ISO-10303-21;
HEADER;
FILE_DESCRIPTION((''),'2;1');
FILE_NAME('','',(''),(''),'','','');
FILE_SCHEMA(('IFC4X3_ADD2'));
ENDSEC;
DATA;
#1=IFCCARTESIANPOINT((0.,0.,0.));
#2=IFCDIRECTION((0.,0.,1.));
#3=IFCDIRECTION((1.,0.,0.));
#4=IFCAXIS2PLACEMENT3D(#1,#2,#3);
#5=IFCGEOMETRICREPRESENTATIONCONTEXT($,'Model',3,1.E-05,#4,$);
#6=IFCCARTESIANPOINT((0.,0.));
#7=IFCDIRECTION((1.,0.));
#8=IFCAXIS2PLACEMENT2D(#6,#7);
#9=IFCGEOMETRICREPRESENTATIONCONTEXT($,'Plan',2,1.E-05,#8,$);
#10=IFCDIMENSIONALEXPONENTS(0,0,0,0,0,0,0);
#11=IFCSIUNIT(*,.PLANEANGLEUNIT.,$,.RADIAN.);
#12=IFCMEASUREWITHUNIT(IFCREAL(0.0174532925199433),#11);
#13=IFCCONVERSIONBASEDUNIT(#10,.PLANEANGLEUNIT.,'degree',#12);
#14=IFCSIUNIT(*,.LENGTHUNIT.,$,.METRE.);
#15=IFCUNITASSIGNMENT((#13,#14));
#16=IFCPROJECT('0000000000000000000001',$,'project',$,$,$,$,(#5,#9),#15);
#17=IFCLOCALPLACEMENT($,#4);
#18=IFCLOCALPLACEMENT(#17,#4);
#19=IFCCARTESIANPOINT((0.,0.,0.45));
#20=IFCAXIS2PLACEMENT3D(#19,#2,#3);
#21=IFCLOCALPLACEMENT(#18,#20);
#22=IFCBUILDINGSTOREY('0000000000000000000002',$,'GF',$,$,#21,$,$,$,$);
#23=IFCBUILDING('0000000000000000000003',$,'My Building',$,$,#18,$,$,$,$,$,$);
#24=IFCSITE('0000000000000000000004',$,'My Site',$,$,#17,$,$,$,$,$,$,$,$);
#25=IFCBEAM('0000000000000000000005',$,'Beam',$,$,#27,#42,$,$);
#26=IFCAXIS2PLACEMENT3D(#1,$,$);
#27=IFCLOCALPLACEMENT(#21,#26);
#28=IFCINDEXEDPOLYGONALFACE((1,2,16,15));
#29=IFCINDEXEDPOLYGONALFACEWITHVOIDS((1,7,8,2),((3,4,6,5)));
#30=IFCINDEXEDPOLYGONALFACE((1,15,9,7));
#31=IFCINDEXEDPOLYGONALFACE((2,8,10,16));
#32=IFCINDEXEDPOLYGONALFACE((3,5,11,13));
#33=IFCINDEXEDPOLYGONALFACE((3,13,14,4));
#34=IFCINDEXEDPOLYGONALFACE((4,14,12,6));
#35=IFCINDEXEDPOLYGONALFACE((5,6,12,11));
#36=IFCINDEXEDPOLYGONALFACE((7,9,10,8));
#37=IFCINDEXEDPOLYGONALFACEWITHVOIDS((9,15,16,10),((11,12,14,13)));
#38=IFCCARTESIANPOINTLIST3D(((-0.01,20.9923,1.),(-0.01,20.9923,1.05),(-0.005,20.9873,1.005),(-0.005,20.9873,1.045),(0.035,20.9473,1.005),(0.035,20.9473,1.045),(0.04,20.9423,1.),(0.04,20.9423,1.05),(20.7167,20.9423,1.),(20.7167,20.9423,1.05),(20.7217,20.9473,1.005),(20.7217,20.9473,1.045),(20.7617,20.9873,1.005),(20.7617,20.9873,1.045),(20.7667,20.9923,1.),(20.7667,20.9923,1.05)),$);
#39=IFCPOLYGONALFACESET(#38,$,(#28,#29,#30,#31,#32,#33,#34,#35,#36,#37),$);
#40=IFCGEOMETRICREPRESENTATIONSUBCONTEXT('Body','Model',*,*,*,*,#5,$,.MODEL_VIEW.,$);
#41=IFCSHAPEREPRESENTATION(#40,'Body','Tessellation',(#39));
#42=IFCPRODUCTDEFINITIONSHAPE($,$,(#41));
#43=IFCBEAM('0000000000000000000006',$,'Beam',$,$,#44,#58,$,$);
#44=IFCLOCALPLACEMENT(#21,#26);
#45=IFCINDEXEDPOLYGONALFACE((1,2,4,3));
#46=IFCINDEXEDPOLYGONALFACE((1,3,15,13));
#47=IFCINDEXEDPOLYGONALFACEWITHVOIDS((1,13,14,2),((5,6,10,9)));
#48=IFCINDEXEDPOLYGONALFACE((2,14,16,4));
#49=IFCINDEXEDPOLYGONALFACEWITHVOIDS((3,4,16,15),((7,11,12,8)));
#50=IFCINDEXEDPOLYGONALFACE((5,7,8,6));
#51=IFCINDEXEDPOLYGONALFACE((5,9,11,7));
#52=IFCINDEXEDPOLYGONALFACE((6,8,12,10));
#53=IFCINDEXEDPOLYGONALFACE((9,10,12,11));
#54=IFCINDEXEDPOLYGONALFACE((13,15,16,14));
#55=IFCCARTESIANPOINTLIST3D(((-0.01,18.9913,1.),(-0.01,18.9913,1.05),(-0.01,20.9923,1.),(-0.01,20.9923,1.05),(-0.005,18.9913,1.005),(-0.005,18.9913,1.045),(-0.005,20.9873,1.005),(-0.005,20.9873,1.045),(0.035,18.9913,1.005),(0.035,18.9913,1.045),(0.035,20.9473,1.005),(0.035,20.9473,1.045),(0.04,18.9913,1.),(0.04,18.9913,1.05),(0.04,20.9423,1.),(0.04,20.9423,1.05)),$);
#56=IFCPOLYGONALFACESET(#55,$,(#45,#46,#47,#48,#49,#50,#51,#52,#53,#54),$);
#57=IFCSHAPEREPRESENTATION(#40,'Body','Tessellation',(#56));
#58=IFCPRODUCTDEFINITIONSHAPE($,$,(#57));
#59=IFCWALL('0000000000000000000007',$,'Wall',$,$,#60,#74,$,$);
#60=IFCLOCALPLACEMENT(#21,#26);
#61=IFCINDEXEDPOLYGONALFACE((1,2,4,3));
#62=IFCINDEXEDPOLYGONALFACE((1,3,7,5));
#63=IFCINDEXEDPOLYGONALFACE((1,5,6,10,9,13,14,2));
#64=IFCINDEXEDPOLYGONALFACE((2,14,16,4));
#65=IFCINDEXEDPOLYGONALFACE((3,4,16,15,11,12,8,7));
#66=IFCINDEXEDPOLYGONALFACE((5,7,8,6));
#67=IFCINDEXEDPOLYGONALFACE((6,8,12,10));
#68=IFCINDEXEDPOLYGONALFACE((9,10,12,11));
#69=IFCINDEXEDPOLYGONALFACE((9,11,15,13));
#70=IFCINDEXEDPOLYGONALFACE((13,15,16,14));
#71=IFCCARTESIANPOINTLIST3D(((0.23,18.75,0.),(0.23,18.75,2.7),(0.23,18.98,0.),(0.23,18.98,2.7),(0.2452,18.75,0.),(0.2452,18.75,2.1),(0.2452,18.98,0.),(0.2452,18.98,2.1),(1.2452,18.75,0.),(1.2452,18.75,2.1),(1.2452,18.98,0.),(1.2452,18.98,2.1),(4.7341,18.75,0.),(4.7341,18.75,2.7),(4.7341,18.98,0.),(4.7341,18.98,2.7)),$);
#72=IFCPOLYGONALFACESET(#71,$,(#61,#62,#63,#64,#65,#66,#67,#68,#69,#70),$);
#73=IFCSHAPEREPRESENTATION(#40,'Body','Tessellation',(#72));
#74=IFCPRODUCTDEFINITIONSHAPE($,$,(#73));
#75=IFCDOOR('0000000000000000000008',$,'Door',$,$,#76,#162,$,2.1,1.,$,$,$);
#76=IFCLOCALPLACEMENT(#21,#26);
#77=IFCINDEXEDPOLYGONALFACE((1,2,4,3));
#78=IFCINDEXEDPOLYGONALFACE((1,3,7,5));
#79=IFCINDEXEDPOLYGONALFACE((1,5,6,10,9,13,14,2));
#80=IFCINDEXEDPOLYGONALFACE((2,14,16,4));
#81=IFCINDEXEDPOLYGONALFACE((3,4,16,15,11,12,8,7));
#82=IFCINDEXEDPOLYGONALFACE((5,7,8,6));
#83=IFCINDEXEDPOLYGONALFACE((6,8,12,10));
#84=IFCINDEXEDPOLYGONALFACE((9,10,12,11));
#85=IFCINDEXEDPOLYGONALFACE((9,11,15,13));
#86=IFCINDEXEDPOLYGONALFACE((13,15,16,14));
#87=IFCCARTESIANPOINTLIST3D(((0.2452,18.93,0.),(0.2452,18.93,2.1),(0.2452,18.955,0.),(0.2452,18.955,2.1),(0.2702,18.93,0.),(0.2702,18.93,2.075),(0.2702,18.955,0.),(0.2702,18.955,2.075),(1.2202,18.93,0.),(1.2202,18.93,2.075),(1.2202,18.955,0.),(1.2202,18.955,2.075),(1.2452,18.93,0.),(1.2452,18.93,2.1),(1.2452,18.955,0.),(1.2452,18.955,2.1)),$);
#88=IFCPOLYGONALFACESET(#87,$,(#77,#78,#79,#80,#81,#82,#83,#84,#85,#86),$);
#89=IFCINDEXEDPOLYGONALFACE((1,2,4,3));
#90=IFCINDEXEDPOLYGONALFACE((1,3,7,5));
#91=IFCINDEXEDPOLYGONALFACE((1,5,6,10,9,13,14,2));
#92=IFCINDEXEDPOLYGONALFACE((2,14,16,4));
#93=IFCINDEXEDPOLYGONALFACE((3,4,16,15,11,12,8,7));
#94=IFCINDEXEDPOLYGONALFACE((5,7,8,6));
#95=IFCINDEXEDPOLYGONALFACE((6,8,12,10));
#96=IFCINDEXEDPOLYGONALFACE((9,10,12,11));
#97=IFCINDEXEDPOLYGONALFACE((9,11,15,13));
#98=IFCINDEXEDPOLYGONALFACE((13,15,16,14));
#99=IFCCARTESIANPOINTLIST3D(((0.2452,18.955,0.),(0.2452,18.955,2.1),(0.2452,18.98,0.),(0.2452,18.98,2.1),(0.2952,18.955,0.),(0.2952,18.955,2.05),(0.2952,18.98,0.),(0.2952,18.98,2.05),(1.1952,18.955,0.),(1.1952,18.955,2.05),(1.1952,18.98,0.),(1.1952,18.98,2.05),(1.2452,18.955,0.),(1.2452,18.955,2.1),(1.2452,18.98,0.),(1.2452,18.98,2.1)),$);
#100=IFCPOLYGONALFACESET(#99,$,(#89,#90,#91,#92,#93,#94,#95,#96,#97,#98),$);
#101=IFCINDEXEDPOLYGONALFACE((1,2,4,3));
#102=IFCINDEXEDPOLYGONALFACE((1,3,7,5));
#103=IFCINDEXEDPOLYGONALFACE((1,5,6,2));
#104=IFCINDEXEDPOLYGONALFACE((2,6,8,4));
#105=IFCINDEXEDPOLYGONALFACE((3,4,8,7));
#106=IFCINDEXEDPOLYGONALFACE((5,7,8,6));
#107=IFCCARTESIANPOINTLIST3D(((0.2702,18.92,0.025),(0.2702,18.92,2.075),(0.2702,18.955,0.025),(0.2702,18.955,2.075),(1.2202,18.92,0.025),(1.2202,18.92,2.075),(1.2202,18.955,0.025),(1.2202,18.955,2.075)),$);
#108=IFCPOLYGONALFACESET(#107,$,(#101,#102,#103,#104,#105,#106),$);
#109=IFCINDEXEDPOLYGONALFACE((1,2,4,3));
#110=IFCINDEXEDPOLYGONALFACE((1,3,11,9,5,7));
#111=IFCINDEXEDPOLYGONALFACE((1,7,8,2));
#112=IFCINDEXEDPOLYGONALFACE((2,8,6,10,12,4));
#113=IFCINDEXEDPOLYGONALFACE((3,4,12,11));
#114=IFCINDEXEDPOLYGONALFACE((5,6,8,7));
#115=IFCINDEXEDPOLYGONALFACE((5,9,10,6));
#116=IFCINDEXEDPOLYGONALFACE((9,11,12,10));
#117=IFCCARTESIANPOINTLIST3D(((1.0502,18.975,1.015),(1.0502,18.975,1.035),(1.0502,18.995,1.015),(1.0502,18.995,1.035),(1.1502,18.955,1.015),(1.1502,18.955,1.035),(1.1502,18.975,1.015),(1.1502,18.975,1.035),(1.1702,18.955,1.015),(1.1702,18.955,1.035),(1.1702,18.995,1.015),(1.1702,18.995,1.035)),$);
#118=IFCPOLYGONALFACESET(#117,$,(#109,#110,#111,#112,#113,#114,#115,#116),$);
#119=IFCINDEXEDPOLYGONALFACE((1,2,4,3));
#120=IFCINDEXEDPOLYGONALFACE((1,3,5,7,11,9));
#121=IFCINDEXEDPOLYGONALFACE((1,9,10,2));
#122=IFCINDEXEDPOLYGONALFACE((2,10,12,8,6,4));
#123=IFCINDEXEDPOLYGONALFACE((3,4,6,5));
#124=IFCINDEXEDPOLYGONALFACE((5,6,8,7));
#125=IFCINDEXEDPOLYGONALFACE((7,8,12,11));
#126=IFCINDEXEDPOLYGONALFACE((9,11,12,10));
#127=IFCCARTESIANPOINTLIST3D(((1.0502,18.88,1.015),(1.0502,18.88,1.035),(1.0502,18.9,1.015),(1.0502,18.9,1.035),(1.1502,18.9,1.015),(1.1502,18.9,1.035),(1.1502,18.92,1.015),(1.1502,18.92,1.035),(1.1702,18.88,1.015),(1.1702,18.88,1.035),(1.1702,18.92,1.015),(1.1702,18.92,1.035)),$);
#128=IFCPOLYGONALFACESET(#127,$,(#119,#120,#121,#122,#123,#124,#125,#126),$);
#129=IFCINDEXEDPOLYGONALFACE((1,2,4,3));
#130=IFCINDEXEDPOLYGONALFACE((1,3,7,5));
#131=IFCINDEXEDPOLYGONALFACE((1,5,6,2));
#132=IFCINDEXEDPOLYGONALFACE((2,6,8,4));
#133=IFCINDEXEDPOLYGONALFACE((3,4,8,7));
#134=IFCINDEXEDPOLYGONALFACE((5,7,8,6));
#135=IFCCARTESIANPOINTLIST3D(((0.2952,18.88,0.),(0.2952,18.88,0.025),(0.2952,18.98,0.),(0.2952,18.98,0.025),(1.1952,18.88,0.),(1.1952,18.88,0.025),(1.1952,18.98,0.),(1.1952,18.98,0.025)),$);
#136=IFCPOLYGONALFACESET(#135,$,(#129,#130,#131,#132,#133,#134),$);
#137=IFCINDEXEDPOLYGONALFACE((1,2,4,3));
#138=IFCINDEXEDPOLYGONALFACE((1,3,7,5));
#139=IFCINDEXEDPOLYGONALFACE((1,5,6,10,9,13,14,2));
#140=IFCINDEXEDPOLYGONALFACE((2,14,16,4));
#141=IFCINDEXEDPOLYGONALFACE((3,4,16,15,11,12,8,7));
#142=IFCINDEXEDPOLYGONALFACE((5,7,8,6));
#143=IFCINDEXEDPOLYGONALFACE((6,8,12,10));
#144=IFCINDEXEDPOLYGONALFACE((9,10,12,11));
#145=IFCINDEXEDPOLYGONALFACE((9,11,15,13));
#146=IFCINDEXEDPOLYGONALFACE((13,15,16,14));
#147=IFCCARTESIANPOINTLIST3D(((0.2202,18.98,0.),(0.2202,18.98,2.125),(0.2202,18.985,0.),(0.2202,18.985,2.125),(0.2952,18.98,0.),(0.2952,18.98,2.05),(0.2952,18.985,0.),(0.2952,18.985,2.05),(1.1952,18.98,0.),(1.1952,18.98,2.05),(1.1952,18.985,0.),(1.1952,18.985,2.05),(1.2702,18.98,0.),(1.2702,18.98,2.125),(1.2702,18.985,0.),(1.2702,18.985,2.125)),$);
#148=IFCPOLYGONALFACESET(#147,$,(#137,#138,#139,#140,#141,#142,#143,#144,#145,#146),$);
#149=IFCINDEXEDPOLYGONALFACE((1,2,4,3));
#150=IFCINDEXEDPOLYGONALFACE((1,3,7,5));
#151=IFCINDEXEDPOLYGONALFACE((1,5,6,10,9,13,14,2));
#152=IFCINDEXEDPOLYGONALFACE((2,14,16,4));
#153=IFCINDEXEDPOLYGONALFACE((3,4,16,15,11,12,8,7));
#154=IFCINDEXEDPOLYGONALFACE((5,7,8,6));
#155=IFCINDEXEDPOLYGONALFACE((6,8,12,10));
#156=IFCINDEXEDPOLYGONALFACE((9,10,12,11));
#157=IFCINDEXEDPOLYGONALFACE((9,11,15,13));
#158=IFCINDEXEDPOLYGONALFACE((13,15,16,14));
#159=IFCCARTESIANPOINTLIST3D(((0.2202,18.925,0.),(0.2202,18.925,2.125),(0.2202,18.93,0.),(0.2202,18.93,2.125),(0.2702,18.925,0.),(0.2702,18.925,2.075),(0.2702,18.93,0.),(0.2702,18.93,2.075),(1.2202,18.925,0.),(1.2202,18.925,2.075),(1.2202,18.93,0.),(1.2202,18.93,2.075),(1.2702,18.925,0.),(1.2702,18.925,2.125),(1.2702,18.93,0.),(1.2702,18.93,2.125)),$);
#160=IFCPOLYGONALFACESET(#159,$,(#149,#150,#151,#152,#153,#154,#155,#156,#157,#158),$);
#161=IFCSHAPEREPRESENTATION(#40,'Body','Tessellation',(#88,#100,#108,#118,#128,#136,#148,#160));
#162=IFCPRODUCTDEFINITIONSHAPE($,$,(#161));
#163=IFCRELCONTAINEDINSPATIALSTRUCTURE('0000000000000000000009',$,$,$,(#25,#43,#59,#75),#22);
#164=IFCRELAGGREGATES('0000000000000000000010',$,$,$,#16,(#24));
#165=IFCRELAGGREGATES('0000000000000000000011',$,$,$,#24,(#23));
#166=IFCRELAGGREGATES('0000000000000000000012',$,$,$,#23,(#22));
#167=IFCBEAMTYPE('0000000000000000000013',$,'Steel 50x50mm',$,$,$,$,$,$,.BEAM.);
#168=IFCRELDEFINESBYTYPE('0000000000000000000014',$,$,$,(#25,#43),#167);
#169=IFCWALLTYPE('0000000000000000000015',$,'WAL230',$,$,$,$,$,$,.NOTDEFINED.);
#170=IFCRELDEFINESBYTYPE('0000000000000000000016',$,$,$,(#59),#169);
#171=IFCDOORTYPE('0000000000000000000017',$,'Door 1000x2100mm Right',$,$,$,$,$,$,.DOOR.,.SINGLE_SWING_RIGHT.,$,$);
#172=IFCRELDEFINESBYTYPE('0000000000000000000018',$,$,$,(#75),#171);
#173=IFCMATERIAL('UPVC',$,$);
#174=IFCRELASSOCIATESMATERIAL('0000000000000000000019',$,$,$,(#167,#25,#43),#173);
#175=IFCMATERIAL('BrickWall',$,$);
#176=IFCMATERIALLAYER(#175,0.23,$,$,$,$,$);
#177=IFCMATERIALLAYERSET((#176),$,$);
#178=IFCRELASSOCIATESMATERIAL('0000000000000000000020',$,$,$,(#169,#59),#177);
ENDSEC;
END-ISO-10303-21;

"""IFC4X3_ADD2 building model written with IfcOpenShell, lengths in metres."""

from ifc_helpers import new_model, entity, si_unit, converted_unit, frame, origin_with_axes, origin_2d_with_axis, place, context, subcontext, project, spatial, line, indexed_curve, hollow_rectangle, outline, extrude, clip, halfspace, shape, source, transform, mapped, material, layer, layer_set, layer_usage, material_profile, profile_set, profile_usage, type_object, type_shapes, element, fill, save


model = new_model("IFC4X3_ADD2")

# Units and contexts
model_context = context("Model", 3, precision=1e-05, world=origin_with_axes())
plan_context = context("Plan", 2, precision=1e-05, world=origin_2d_with_axis())
body_context_1 = subcontext(model_context, "Body", "Model", "MODEL_VIEW")
body_context_2 = subcontext(plan_context, "Body", "Plan", "PLAN_VIEW")
ifc_project = project(units=[converted_unit("PLANEANGLEUNIT", "degree", entity("IfcReal", 0.0174532925199433), si_unit("PLANEANGLEUNIT", "RADIAN"), dimensions=[0, 0, 0, 0, 0, 0, 0]), si_unit("LENGTHUNIT", "METRE")], contexts=[model_context, plan_context])

# Site, building, storey
site_placement = place(None, origin_with_axes())
site = spatial("IfcSite", under=ifc_project, at=site_placement, Name="My Site")
building_placement = place(site_placement, origin_with_axes())
building = spatial("IfcBuilding", under=site, at=building_placement, Name="My Building")
storey_placement = place(building_placement, frame((0.0, 0.0, 0.45), z_axis=(0.0, 0.0, 1.0), x_axis=(1.0, 0.0, 0.0)))
storey = spatial("IfcBuildingStorey", under=building, at=storey_placement, Name="GF")

# Beams
ifc_material_1 = material(Name="UPVC")
ifc_material_profile_1 = material_profile(ifc_material_1, hollow_rectangle(XDim=0.05, YDim=0.05, WallThickness=0.005))
ifc_material_profile_2 = material_profile(ifc_material_1, hollow_rectangle(XDim=0.05, YDim=0.05, WallThickness=0.005))
ifc_profile_set = profile_set([ifc_material_profile_1, ifc_material_profile_2])
ifc_profile_usage_1 = profile_usage(ifc_profile_set, cardinal=5)
beam_type = type_object("IfcBeamType", Name="Steel 50x50mm", PredefinedType="BEAM", material=ifc_profile_set)
beam_1_placement = place(storey_placement, frame((-0.01, 20.9673, 1.025), z_axis=(1.0, 0.0, 0.0), x_axis=(0.0, 1.0, 0.0)))
element("IfcBeam", 1, at=beam_1_placement, inside=storey, type_object=beam_type, material=ifc_profile_usage_1, Name="Beam", context=body_context_1, shape_type="Clipping", body=[
    clip(clip(extrude(hollow_rectangle(XDim=0.05, YDim=0.05, WallThickness=0.005), origin_with_axes(), (0.0, 0.0, 1.0), 20.7767), halfspace(frame((0.025, -1.475, 20.7767), z_axis=(-0.707107, 0.0, 0.707107), x_axis=(0.0, 1.0, 0.0)), False)), halfspace(frame((0.025, -1.475, 0.0), z_axis=(-0.707112, 0.0, -0.707101), x_axis=(0.0, 1.0, 0.0)), False)),
])
ifc_profile_usage_2 = profile_usage(ifc_profile_set, cardinal=5)
beam_2_placement = place(storey_placement, frame((0.015, 18.9913, 1.025), z_axis=(0.0, 1.0, 0.0), x_axis=(-1.0, 0.0, 0.0)))
element("IfcBeam", 2, at=beam_2_placement, inside=storey, type_object=beam_type, material=ifc_profile_usage_2, Name="Beam", context=body_context_1, shape_type="Clipping", body=[
    clip(extrude(hollow_rectangle(XDim=0.05, YDim=0.05, WallThickness=0.005), origin_with_axes(), (0.0, 0.0, 1.0), 2.0009), halfspace(frame((0.025, -1.475, 2.0009), z_axis=(-0.707101, 0.0, 0.707112), x_axis=(0.0, 1.0, 0.0)), False)),
])

# Wall, opening, door
ifc_material_2 = material(Name="BrickWall")
ifc_layer_1 = layer(ifc_material_2, 0.23)
ifc_layer_set_1 = layer_set([ifc_layer_1])
ifc_layer_usage_1 = layer_usage(ifc_layer_set_1, "AXIS2", "POSITIVE", 0.0)
wall_type_1 = type_object("IfcWallType", Name="WAL230", PredefinedType="NOTDEFINED", material=ifc_layer_set_1)
wall_1_placement = place(storey_placement, frame((4.7341, 18.98, 0.0), z_axis=(0.0, 0.0, 1.0), x_axis=(-1.0, 0.0, 0.0)))
wall_1 = element("IfcWall", 3, at=wall_1_placement, inside=storey, type_object=wall_type_1, material=ifc_layer_usage_1, Name="Wall", context=body_context_1, shape_type="SweptSolid", body=[
    extrude(outline(indexed_curve([(0.0, 0.0), (0.0, 0.23), (4.5041, 0.23), (4.5041, 0.0), (0.0, 0.0)], self_intersect=False)), origin_with_axes(), (0.0, 0.0, 1.0), 2.7),
])
shared_shape_1 = source(origin_with_axes(), body_context_1, "Body", "SweptSolid", [
    extrude(outline(indexed_curve([(0.0, 0.0), (1.0, 0.0), (1.0, 2.1), (0.0, 2.1)], segments=[line(1, 2, 3, 4, 1)])), frame((0.0, -0.6, 0.0), z_axis=(0.0, -1.0, 0.0), x_axis=(1.0, 0.0, 0.0)), (0.0, 0.0, -1.0), 1.2),
])
opening_1_placement = place(wall_1_placement, frame((3.4889, 0.0, 0.0), z_axis=(0.0, 0.0, 1.0), x_axis=(1.0, 0.0, 0.0)))
opening_1 = element("IfcOpeningElement", 4, at=opening_1_placement, cuts=wall_1, PredefinedType="OPENING", context=body_context_1, shape_type="MappedRepresentation", body=[
    mapped(shared_shape_1, transform((0.0, 0.0, 0.0), x_axis=(1.0, 0.0, 0.0), y_axis=(0.0, 1.0, 0.0), z_axis=(0.0, 0.0, 1.0), scale=1.0)),
])
door_type_1 = type_object("IfcDoorType", Name="Door 1000x2100mm Right", OperationType="SINGLE_SWING_RIGHT", PredefinedType="DOOR")
shared_shape_2 = source(origin_with_axes(), body_context_1, "Body", "SweptSolid", [
    extrude(outline(indexed_curve([(0.0, 0.0), (0.0, 2.1), (1.0, 2.1), (1.0, 0.0), (0.975, 0.0), (0.975, 2.075), (0.025, 2.075), (0.025, 0.0)], segments=[line(1, 2, 3, 4, 5, 6, 7, 8, 1)])), frame((0.0, 0.025, 0.0), z_axis=(0.0, -1.0, 0.0), x_axis=(1.0, 0.0, 0.0)), (0.0, 0.0, -1.0), 0.025),
    extrude(outline(indexed_curve([(0.0, 0.0), (0.0, 2.1), (1.0, 2.1), (1.0, 0.0), (0.95, 0.0), (0.95, 2.05), (0.05, 2.05), (0.05, 0.0)], segments=[line(1, 2, 3, 4, 5, 6, 7, 8, 1)])), frame((0.0, 0.0, 0.0), z_axis=(0.0, -1.0, 0.0), x_axis=(1.0, 0.0, 0.0)), (0.0, 0.0, -1.0), 0.025),
    extrude(outline(indexed_curve([(0.0, 0.0), (0.95, 0.0), (0.95, 0.035), (0.0, 0.035)], segments=[line(1, 2, 3, 4, 1)])), frame((0.025, 0.025, 0.025), z_axis=(0.0, 0.0, 1.0), x_axis=(1.0, 0.0, 0.0)), (0.0, 0.0, 1.0), 2.05),
    extrude(outline(indexed_curve([(0.0, 0.0), (0.0, -0.04), (0.12, -0.04), (0.12, -0.02), (0.02, -0.02), (0.02, 0.0)], segments=[line(1, 2, 3, 4, 5, 6, 1)])), frame((0.075, 0.025, 1.015), z_axis=(0.0, 0.0, 1.0), x_axis=(1.0, 0.0, 0.0)), (0.0, 0.0, 1.0), 0.02),
    extrude(outline(indexed_curve([(0.0, 0.0), (0.0, 0.04), (0.12, 0.04), (0.12, 0.02), (0.02, 0.02), (0.02, 0.0)], segments=[line(1, 2, 3, 4, 5, 6, 1)])), frame((0.075, 0.06, 1.015), z_axis=(0.0, 0.0, 1.0), x_axis=(1.0, 0.0, 0.0)), (0.0, 0.0, 1.0), 0.02),
    extrude(outline(indexed_curve([(0.0, 0.0), (0.9, 0.0), (0.9, 0.1), (0.0, 0.1)], segments=[line(1, 2, 3, 4, 1)])), frame((0.05, 0.0, 0.0), z_axis=(0.0, 0.0, 1.0), x_axis=(1.0, 0.0, 0.0)), (0.0, 0.0, 1.0), 0.025),
    extrude(outline(indexed_curve([(0.0, 0.0), (0.0, 2.125), (1.05, 2.125), (1.05, 0.0), (0.975, 0.0), (0.975, 2.05), (0.075, 2.05), (0.075, 0.0)], segments=[line(1, 2, 3, 4, 5, 6, 7, 8, 1)])), frame((-0.025, -0.005, 0.0), z_axis=(0.0, -1.0, 0.0), x_axis=(1.0, 0.0, 0.0)), (0.0, 0.0, -1.0), 0.005),
    extrude(outline(indexed_curve([(0.0, 0.0), (0.0, 2.125), (1.05, 2.125), (1.05, 0.0), (1.0, 0.0), (1.0, 2.075), (0.05, 2.075), (0.05, 0.0)], segments=[line(1, 2, 3, 4, 5, 6, 7, 8, 1)])), frame((-0.025, 0.05, 0.0), z_axis=(0.0, -1.0, 0.0), x_axis=(1.0, 0.0, 0.0)), (0.0, 0.0, -1.0), 0.005),
])
shared_shape_3 = source(origin_with_axes(), body_context_2, "Body", "Curve2D", [
    entity("IfcIndexedPolyCurve", entity("IfcCartesianPointList2D", [[0.0, 0.0], [0.0, 0.05], [0.025, 0.05], [0.025, 0.025], [0.05, 0.025], [0.05, 0.0]]), [entity("IfcLineIndex", [1, 2, 3, 4, 5, 6, 1])]),
    entity("IfcIndexedPolyCurve", entity("IfcCartesianPointList2D", [[1.0, 0.0], [1.0, 0.05], [0.975, 0.05], [0.975, 0.025], [0.95, 0.025], [0.95, 0.0]]), [entity("IfcLineIndex", [1, 2, 3, 4, 5, 6, 1])]),
    entity("IfcTrimmedCurve", entity("IfcEllipse", entity("IfcAxis2Placement2D", entity("IfcCartesianPoint", [0.94, 0.05]), entity("IfcDirection", [1.0, 0.0])), 0.915, 0.95), [entity("IfcCartesianPoint", [0.94, 1.0])], [entity("IfcCartesianPoint", [0.025, 0.05])], True, "CARTESIAN"),
    entity("IfcIndexedPolyCurve", entity("IfcCartesianPointList2D", [[0.975, 0.05], [0.94, 0.05], [0.94, 1.0], [0.975, 1.0]]), [entity("IfcLineIndex", [1, 2, 3, 4, 1])]),
])
type_shapes(door_type_1, [shared_shape_2, shared_shape_3])
door_1_placement = place(opening_1_placement, frame((0.0, 0.0, 0.0), z_axis=(0.0, 0.0, 1.0), x_axis=(1.0, 0.0, 0.0)))
door_1 = element("IfcDoor", 5, at=door_1_placement, inside=storey, type_object=door_type_1, Name="Door", OverallHeight=2.1, OverallWidth=1.0, shapes=[
    shape(body_context_1, "Body", "MappedRepresentation", [mapped(shared_shape_2, transform((0.0, 0.0, 0.0), x_axis=(1.0, 0.0, 0.0), y_axis=(0.0, 1.0, 0.0), z_axis=(0.0, 0.0, 1.0), scale=1.0))]),
    shape(body_context_2, "Body", "MappedRepresentation", [mapped(shared_shape_3, transform((0.0, 0.0, 0.0), x_axis=(1.0, 0.0, 0.0), y_axis=(0.0, 1.0, 0.0), z_axis=(0.0, 0.0, 1.0), scale=1.0))]),
])
fill(opening_1, door_1)

save(model, "model.ifc")
